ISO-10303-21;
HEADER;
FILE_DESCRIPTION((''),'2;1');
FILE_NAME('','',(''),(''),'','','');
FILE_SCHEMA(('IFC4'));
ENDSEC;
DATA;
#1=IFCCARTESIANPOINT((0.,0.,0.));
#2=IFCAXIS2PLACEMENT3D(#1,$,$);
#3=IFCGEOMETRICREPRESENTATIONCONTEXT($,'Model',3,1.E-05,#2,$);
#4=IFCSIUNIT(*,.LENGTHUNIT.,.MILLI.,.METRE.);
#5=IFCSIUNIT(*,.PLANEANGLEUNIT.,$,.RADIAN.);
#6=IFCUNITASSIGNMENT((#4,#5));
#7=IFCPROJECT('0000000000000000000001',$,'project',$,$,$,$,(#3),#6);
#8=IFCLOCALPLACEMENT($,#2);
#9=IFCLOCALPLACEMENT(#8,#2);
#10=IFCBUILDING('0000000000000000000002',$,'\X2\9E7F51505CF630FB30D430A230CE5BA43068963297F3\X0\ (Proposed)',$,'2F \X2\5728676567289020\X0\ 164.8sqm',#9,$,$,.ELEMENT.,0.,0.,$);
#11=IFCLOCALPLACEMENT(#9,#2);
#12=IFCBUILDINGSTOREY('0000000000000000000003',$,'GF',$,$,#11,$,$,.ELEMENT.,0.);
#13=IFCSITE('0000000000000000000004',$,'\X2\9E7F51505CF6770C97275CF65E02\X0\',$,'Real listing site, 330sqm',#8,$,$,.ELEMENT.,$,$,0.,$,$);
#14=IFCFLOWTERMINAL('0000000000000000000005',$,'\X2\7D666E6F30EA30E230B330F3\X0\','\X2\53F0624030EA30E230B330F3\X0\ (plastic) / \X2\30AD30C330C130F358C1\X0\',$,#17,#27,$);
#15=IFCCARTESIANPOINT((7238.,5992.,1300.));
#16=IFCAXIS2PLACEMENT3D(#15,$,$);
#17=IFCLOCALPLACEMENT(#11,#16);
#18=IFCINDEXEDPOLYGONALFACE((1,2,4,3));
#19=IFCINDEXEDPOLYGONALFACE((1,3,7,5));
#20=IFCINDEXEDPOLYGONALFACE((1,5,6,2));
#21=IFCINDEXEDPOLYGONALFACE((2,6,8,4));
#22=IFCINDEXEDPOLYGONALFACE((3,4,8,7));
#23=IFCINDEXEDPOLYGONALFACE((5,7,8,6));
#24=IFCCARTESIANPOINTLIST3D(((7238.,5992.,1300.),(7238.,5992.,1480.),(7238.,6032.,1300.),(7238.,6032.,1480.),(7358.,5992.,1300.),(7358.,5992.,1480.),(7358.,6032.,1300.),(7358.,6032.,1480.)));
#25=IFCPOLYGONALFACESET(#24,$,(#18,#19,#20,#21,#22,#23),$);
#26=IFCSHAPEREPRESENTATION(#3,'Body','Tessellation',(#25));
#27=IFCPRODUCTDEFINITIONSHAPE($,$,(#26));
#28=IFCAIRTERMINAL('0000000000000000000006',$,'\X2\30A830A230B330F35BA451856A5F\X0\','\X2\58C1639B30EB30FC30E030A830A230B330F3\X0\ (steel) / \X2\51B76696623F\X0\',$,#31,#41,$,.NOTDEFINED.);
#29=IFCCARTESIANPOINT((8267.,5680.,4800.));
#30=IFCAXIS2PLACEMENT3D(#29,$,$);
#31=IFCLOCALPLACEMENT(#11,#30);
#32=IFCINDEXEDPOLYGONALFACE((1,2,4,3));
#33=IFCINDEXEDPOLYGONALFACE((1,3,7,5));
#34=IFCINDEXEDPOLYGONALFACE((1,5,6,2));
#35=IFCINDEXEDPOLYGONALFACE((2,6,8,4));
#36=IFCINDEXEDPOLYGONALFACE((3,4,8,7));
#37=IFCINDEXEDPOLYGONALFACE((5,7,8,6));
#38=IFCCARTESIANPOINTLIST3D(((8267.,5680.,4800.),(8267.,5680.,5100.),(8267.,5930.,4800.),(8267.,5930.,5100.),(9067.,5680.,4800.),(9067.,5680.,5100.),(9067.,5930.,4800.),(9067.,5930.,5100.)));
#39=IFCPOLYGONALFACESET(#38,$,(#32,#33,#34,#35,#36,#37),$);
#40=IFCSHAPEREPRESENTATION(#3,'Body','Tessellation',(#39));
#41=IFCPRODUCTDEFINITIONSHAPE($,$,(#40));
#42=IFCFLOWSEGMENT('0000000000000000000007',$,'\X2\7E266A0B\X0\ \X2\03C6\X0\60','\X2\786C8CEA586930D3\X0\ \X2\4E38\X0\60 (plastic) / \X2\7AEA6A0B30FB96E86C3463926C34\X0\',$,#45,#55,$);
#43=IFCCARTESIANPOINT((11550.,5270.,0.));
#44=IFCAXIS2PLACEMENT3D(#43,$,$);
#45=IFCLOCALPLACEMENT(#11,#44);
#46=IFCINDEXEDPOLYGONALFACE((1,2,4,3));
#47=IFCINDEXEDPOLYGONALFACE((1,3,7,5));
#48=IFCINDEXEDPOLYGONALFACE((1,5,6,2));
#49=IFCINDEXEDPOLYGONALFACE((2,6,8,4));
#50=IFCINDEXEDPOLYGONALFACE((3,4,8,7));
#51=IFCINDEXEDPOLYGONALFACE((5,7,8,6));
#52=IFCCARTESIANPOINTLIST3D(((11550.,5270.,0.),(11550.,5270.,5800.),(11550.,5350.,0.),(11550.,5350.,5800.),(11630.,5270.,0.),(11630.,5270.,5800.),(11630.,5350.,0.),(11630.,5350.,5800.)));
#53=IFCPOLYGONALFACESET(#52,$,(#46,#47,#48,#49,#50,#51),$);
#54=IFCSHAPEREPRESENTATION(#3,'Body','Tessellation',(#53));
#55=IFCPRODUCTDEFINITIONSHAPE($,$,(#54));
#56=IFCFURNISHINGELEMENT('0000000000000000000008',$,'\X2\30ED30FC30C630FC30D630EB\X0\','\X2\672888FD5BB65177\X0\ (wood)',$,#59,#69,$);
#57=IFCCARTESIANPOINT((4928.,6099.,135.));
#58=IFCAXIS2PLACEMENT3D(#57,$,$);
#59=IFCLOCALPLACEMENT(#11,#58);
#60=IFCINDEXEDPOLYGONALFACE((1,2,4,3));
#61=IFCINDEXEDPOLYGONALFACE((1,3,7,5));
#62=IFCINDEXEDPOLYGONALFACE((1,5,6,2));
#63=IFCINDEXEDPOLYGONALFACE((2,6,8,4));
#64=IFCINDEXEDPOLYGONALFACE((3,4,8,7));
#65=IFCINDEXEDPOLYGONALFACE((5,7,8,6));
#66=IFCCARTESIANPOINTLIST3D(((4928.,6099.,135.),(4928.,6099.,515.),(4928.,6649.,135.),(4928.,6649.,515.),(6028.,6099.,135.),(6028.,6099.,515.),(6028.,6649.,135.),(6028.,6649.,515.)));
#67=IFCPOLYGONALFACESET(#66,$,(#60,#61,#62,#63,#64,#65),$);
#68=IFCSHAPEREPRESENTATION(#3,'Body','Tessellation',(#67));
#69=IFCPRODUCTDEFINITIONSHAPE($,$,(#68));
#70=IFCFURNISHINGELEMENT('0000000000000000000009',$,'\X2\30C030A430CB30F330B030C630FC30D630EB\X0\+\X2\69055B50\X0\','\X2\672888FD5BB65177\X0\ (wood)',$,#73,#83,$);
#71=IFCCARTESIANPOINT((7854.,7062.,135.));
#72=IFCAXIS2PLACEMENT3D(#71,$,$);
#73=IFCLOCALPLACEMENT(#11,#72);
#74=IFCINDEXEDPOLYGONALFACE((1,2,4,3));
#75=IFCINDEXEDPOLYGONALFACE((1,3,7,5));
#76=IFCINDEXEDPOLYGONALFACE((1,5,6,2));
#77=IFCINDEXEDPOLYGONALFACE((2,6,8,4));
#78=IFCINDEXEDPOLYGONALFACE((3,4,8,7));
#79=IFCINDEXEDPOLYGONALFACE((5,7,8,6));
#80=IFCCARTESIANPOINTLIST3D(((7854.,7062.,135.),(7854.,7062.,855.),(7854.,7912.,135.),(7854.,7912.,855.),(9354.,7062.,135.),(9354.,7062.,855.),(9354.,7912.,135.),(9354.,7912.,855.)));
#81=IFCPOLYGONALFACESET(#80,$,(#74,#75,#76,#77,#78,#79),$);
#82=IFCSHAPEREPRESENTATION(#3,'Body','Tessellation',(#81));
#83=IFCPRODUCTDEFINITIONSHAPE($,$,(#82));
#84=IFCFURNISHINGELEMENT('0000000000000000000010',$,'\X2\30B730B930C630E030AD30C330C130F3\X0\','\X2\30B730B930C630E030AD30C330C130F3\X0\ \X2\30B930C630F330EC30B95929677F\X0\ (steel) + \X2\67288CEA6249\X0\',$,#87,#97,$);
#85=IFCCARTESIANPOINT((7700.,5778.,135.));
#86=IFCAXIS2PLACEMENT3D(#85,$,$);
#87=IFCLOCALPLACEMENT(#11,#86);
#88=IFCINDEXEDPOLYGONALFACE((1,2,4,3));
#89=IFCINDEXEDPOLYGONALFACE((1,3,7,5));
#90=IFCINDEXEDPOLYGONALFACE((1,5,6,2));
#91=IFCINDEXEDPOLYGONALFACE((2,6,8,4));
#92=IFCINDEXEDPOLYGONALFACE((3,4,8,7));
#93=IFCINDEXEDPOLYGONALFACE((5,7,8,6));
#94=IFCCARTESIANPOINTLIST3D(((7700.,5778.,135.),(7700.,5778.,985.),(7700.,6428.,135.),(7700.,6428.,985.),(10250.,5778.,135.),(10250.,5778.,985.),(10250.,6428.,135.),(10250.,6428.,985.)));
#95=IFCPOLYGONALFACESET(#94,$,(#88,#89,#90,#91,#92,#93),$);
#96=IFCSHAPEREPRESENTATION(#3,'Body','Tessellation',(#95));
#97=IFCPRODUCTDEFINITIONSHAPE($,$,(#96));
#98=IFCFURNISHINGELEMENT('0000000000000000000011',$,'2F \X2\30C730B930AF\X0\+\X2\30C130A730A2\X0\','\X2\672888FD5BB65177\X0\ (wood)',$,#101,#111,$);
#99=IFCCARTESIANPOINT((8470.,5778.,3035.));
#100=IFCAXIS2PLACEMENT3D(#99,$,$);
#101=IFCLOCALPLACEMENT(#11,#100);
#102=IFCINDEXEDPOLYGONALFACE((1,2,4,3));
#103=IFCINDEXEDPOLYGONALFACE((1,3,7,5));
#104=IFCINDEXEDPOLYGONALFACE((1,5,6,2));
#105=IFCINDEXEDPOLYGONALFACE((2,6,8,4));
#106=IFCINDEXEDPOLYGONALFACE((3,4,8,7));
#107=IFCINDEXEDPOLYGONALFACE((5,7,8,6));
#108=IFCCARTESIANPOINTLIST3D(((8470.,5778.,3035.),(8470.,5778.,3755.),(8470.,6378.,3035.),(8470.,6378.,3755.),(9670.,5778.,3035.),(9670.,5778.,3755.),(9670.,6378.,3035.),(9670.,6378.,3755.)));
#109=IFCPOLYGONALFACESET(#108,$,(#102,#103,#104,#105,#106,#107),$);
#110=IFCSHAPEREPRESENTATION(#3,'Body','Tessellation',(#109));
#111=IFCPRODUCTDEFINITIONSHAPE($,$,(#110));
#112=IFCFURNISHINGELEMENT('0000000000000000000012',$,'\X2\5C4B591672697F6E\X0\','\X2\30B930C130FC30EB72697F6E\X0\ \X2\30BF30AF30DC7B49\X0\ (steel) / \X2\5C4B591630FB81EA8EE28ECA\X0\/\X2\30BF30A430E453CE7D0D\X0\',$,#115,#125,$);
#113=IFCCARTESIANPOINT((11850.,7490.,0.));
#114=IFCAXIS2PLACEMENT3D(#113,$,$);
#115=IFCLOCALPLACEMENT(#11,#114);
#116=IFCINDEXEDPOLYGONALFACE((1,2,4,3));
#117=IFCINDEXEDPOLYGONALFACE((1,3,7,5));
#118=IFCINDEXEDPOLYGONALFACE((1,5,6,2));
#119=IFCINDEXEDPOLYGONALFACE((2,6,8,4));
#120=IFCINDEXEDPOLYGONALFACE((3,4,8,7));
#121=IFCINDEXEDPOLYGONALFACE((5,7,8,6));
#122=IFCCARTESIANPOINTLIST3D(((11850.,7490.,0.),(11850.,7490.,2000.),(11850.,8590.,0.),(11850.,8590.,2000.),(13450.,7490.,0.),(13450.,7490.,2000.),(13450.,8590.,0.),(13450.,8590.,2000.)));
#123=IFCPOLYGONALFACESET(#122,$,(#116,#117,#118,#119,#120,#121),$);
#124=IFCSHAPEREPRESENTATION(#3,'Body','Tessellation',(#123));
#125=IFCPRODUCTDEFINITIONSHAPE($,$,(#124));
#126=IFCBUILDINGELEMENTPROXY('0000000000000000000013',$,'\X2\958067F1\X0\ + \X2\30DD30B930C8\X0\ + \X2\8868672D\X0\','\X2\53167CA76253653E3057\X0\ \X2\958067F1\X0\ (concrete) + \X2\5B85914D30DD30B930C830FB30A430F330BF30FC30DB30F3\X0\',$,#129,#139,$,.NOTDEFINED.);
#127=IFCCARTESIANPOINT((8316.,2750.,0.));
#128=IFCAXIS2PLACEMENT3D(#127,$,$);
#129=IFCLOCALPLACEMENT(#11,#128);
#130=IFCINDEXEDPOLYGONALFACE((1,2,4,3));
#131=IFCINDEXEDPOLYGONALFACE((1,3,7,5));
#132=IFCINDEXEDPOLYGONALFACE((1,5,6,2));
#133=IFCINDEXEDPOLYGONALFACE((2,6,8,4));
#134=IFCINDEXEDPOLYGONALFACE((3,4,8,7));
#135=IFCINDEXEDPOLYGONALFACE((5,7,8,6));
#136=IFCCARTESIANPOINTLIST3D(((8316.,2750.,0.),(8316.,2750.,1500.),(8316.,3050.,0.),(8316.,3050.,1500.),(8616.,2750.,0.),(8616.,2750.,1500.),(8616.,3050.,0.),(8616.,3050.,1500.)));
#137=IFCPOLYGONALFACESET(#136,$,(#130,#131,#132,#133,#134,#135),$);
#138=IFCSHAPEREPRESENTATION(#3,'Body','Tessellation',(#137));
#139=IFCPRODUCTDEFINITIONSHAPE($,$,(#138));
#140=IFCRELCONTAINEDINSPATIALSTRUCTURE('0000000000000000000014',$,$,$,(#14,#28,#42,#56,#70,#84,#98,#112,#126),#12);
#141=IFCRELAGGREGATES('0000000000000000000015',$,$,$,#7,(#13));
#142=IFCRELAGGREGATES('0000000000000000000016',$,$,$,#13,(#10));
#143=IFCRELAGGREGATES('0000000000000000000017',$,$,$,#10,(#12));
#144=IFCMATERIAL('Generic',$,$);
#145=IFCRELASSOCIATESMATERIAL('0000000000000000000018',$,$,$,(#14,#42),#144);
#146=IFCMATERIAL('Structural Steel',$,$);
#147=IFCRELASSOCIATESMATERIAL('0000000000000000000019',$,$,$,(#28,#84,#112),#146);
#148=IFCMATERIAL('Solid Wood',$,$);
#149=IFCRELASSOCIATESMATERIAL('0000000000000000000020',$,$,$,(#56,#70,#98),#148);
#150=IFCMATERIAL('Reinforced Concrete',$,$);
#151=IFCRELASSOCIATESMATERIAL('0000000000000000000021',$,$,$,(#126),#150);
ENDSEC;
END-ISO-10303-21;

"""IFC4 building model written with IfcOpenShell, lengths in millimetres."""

from ifc_helpers import new_model, si_unit, frame, frame_2d, origin, place, context, project, spatial, rectangle, extrude, material, element, save


model = new_model("IFC4")

# Units and contexts
model_context = context("Model", 3, precision=1e-05, world=origin())
ifc_project = project(units=[si_unit("LENGTHUNIT", "METRE", prefix="MILLI"), si_unit("PLANEANGLEUNIT", "RADIAN")], contexts=[model_context])

# Site, building, storey
site_placement = place(None, origin())
site = spatial("IfcSite", under=ifc_project, at=site_placement, Name="鹿児島県霧島市", ObjectType="Real listing site, 330sqm", CompositionType="ELEMENT", RefElevation=0.0)
building_placement = place(site_placement, origin())
building = spatial("IfcBuilding", under=site, at=building_placement, Name="鹿児島・ピアノ室と防音 (Proposed)", ObjectType="2F 在来木造 164.8sqm", CompositionType="ELEMENT", ElevationOfRefHeight=0.0, ElevationOfTerrain=0.0)
storey_placement = place(building_placement, origin())
storey = spatial("IfcBuildingStorey", under=building, at=storey_placement, Name="GF", CompositionType="ELEMENT", Elevation=0.0)

# Shared definitions
ifc_material_1 = material(Name="Solid Wood")

# Shared definitions
ifc_material_2 = material(Name="Reinforced Concrete")

# Shared definitions
ifc_material_3 = material(Name="Structural Steel")

# Flow terminal
ifc_material_4 = material(Name="Generic")
flow_terminal_1_placement = place(storey_placement, frame((7238.0, 5992.0, 1300.0)))
element("IfcFlowTerminal", 1, at=flow_terminal_1_placement, inside=storey, material=ifc_material_4, Name="給湯リモコン", Description="台所リモコン (plastic) / キッチン壁", context=model_context, shape_type="SweptSolid", body=[
    extrude(rectangle(XDim=120.0, YDim=40.0, at=frame_2d((60.0, 20.0))), frame((7238.0, 5992.0, 1300.0)), (0.0, 0.0, 1.0), 180.0),
])

# Air terminal
air_terminal_placement = place(storey_placement, frame((8267.0, 5680.0, 4800.0)))
element("IfcAirTerminal", 2, at=air_terminal_placement, inside=storey, material=ifc_material_3, Name="エアコン室内機", Description="壁掛ルームエアコン (steel) / 冷暖房", PredefinedType="NOTDEFINED", context=model_context, shape_type="SweptSolid", body=[
    extrude(rectangle(XDim=800.0, YDim=250.0, at=frame_2d((400.0, 125.0))), frame((8267.0, 5680.0, 4800.0)), (0.0, 0.0, 1.0), 300.0),
])

# Flow segment
flow_segment_placement = place(storey_placement, frame((11550.0, 5270.0, 0.0)))
element("IfcFlowSegment", 3, at=flow_segment_placement, inside=storey, material=ifc_material_4, Name="縦樋 φ60", Description="硬質塩ビ 丸60 (plastic) / 竪樋・雨水排水", context=model_context, shape_type="SweptSolid", body=[
    extrude(rectangle(XDim=80.0, YDim=80.0, at=frame_2d((40.0, 40.0))), frame((11550.0, 5270.0, 0.0)), (0.0, 0.0, 1.0), 5800.0),
])

# Furnishing elements
furnishing_1_placement = place(storey_placement, frame((4928.0, 6099.0, 135.0)))
element("IfcFurnishingElement", 4, at=furnishing_1_placement, inside=storey, material=ifc_material_1, Name="ローテーブル", Description="木製家具 (wood)", context=model_context, shape_type="SweptSolid", body=[
    extrude(rectangle(XDim=1100.0, YDim=550.0, at=frame_2d((550.0, 275.0))), frame((4928.0, 6099.0, 135.0)), (0.0, 0.0, 1.0), 380.0),
])
furnishing_2_placement = place(storey_placement, frame((7854.0, 7062.0, 135.0)))
element("IfcFurnishingElement", 5, at=furnishing_2_placement, inside=storey, material=ifc_material_1, Name="ダイニングテーブル+椅子", Description="木製家具 (wood)", context=model_context, shape_type="SweptSolid", body=[
    extrude(rectangle(XDim=1500.0, YDim=850.0, at=frame_2d((750.0, 425.0))), frame((7854.0, 7062.0, 135.0)), (0.0, 0.0, 1.0), 720.0),
])
furnishing_3_placement = place(storey_placement, frame((7700.0, 5778.0, 135.0)))
element("IfcFurnishingElement", 6, at=furnishing_3_placement, inside=storey, material=ifc_material_3, Name="システムキッチン", Description="システムキッチン ステンレス天板 (steel) + 木質扉", context=model_context, shape_type="SweptSolid", body=[
    extrude(rectangle(XDim=2550.0, YDim=650.0, at=frame_2d((1275.0, 325.0))), frame((7700.0, 5778.0, 135.0)), (0.0, 0.0, 1.0), 850.0),
])
furnishing_4_placement = place(storey_placement, frame((8470.0, 5778.0, 3035.0)))
element("IfcFurnishingElement", 7, at=furnishing_4_placement, inside=storey, material=ifc_material_1, Name="2F デスク+チェア", Description="木製家具 (wood)", context=model_context, shape_type="SweptSolid", body=[
    extrude(rectangle(XDim=1200.0, YDim=600.0, at=frame_2d((600.0, 300.0))), frame((8470.0, 5778.0, 3035.0)), (0.0, 0.0, 1.0), 720.0),
])
furnishing_5_placement = place(storey_placement, frame((11850.0, 7490.0, 0.0)))
element("IfcFurnishingElement", 8, at=furnishing_5_placement, inside=storey, material=ifc_material_3, Name="屋外物置", Description="スチール物置 タクボ等 (steel) / 屋外・自転車/タイヤ収納", context=model_context, shape_type="SweptSolid", body=[
    extrude(rectangle(XDim=1600.0, YDim=1100.0, at=frame_2d((800.0, 550.0))), frame((11850.0, 7490.0, 0.0)), (0.0, 0.0, 1.0), 2000.0),
])

# Building element proxy
proxy_placement = place(storey_placement, frame((8316.0, 2750.0, 0.0)))
element("IfcBuildingElementProxy", 9, at=proxy_placement, inside=storey, material=ifc_material_2, Name="門柱 + ポスト + 表札", Description="化粧打放し 門柱 (concrete) + 宅配ポスト・インターホン", PredefinedType="NOTDEFINED", context=model_context, shape_type="SweptSolid", body=[
    extrude(rectangle(XDim=300.0, YDim=300.0, at=frame_2d((150.0, 150.0))), frame((8316.0, 2750.0, 0.0)), (0.0, 0.0, 1.0), 1500.0),
])

save(model, "model.ifc")
